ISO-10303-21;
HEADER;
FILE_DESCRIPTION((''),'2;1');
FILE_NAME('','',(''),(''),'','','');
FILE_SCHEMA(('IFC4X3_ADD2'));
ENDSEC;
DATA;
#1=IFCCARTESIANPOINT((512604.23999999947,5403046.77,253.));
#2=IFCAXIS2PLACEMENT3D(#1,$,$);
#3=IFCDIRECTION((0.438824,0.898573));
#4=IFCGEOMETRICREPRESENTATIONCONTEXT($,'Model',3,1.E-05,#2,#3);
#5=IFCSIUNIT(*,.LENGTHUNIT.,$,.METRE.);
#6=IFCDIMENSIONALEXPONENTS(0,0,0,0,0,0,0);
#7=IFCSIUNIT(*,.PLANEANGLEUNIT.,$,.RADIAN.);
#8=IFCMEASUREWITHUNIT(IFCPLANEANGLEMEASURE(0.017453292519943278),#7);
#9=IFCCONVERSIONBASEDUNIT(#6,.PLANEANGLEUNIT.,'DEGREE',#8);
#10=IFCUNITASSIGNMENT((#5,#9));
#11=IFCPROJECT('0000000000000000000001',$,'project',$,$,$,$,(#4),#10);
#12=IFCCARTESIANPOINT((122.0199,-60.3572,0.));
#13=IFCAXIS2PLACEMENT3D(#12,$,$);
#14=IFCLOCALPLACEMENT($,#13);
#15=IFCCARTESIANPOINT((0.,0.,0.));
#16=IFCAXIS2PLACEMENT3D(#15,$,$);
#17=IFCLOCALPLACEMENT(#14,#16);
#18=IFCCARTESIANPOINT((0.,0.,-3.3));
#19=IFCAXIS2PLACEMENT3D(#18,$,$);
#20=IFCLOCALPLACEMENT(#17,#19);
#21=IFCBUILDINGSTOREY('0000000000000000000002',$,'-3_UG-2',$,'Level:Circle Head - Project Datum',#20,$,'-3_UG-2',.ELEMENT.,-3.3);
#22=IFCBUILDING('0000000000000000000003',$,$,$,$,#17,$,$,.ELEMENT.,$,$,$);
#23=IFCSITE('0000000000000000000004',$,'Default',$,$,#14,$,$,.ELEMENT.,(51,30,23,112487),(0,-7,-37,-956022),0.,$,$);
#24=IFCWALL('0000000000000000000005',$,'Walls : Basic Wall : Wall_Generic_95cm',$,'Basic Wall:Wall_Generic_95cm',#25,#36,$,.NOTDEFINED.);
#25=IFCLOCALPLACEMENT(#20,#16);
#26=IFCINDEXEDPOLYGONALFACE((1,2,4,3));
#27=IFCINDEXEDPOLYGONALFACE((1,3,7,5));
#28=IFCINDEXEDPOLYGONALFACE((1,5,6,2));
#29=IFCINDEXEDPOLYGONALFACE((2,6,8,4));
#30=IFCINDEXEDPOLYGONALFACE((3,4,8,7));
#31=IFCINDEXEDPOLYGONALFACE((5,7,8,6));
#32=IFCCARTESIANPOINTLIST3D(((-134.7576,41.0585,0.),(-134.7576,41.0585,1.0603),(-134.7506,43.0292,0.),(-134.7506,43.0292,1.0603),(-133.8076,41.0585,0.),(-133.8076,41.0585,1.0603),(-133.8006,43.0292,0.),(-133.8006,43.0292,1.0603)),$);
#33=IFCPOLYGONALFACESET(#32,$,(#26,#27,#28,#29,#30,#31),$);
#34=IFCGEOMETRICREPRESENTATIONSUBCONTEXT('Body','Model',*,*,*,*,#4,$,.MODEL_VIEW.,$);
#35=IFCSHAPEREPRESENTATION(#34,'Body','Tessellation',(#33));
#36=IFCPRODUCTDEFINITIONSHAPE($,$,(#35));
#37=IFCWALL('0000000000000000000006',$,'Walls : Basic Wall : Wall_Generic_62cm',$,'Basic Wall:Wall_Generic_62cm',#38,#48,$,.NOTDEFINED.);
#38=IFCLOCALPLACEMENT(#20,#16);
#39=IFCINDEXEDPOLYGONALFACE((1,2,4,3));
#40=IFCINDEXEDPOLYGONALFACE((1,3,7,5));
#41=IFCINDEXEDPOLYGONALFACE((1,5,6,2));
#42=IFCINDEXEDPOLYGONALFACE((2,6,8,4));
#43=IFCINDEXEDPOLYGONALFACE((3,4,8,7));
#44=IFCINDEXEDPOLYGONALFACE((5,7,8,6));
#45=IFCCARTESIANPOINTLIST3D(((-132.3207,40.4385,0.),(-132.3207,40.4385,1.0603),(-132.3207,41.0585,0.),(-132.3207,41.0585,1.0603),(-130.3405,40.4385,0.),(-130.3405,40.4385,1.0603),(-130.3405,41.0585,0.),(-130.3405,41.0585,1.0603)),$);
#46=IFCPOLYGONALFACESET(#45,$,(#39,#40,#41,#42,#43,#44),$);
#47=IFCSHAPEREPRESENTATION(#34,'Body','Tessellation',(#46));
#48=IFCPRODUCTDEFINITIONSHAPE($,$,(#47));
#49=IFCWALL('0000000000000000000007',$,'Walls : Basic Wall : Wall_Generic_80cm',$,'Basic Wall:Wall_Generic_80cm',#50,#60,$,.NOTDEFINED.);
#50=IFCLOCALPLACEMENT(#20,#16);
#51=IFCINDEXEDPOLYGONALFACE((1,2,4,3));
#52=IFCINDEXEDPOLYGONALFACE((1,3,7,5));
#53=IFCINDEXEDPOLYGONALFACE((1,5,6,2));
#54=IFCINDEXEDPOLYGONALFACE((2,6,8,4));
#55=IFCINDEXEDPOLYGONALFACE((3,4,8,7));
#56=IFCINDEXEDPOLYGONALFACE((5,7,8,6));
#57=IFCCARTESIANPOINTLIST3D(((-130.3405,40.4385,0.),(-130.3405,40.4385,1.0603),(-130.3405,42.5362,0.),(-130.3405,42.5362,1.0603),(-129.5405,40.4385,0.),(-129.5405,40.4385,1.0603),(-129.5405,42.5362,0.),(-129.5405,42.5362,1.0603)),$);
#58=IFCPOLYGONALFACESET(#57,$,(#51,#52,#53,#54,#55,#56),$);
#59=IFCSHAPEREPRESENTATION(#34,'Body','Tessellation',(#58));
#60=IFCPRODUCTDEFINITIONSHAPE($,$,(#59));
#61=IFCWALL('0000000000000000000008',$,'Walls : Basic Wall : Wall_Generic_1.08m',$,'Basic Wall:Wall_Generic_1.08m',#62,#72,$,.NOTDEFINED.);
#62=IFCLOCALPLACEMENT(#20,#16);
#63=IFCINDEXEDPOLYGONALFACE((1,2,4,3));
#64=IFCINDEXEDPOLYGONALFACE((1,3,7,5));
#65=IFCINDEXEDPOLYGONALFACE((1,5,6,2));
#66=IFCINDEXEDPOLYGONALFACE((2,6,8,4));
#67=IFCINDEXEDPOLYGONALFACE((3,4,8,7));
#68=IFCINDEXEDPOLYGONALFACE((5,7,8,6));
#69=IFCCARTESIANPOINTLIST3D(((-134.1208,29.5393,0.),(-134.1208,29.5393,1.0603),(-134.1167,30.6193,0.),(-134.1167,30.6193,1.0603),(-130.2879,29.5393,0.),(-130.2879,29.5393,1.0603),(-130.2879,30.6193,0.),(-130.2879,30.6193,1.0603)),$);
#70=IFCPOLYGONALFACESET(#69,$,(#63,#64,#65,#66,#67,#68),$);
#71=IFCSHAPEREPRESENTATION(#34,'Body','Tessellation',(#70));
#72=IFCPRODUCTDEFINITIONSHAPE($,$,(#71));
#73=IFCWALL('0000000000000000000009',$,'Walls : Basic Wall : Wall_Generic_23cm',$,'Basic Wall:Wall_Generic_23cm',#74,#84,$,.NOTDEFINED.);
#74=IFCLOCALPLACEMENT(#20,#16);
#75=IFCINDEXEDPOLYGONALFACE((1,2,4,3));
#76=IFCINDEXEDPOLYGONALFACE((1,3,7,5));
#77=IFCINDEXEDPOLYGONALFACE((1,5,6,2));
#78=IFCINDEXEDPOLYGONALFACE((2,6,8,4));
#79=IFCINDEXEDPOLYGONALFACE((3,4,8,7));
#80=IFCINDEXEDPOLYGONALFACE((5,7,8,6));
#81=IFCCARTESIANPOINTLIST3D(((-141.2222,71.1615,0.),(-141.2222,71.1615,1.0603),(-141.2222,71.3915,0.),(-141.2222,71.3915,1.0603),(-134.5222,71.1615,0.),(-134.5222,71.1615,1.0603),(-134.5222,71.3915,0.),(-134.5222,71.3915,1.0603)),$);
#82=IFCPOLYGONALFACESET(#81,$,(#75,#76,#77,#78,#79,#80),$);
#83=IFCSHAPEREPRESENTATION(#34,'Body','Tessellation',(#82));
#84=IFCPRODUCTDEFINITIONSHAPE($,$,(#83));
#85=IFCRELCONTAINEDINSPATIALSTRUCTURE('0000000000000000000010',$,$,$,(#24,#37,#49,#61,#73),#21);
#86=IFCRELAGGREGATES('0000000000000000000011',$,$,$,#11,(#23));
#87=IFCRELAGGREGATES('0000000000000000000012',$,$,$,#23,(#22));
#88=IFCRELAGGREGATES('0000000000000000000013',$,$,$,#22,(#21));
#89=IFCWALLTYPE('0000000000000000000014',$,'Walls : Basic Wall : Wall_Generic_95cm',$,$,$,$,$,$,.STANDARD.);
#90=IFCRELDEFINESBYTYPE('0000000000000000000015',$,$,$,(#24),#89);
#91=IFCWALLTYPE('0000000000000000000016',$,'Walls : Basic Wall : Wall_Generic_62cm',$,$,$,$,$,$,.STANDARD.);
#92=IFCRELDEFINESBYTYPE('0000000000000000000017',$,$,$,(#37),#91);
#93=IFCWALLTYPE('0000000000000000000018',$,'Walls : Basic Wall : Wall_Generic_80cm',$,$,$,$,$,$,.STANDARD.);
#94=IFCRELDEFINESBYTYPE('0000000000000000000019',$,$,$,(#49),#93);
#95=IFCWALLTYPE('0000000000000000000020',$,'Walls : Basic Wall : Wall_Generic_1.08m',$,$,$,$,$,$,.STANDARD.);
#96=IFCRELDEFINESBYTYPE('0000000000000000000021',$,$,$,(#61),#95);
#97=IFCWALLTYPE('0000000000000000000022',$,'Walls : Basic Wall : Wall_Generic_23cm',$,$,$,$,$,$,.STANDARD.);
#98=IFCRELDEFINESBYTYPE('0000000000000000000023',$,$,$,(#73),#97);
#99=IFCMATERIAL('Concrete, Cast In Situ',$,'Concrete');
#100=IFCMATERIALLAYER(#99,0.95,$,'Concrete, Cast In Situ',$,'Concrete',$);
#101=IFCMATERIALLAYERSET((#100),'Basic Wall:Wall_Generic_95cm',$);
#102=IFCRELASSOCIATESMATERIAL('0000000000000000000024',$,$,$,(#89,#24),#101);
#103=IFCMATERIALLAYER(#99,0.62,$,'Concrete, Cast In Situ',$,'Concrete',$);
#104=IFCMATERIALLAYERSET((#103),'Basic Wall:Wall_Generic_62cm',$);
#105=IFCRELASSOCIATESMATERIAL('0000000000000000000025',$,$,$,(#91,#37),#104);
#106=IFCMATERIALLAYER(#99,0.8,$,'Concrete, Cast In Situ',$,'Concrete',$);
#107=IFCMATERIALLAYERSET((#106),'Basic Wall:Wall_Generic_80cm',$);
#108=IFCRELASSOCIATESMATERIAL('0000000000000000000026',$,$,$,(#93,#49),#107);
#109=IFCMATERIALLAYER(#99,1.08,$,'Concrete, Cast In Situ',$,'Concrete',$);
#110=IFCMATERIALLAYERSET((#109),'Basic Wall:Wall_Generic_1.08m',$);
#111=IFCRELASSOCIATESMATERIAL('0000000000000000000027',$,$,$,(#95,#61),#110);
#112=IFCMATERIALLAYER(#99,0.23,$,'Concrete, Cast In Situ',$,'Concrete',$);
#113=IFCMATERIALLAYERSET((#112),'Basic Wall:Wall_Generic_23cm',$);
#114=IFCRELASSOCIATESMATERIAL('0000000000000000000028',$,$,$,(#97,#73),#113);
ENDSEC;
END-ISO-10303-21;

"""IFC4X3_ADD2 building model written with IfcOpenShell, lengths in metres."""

from ifc_helpers import new_model, entity, si_unit, converted_unit, direction, frame, frame_2d, origin, place, context, subcontext, project, spatial, polyline, rectangle, outline, extrude, clip, halfspace, material, layer, layer_set, type_object, element, save


model = new_model("IFC4X3_ADD2")

# Units and contexts
model_context = context("Model", 3, precision=1e-05, world=frame((512604.23999999947, 5403046.77, 253.0)), true_north=direction((0.438824, 0.898573)))
body_context = subcontext(model_context, "Body", "Model", "MODEL_VIEW")
ifc_project = project(units=[si_unit("LENGTHUNIT", "METRE"), converted_unit("PLANEANGLEUNIT", "DEGREE", entity("IfcPlaneAngleMeasure", 0.017453292519943278), si_unit("PLANEANGLEUNIT", "RADIAN"), dimensions=[0, 0, 0, 0, 0, 0, 0])], contexts=[model_context])

# Site, building, storey
site_placement = place(None, frame((122.0199, -60.3572, 0.0)))
site = spatial("IfcSite", under=ifc_project, at=site_placement, Name="Default", CompositionType="ELEMENT", RefLatitude=(51, 30, 23, 112487), RefLongitude=(0, -7, -37, -956022), RefElevation=0.0)
building_placement = place(site_placement, origin())
building = spatial("IfcBuilding", under=site, at=building_placement, CompositionType="ELEMENT")
storey_placement = place(building_placement, frame((0.0, 0.0, -3.3)))
storey = spatial("IfcBuildingStorey", under=building, at=storey_placement, Name="-3_UG-2", ObjectType="Level:Circle Head - Project Datum", LongName="-3_UG-2", CompositionType="ELEMENT", Elevation=-3.3)

# Walls
ifc_material_1 = material(Name="Concrete, Cast In Situ", Category="Concrete")
ifc_layer_1 = layer(ifc_material_1, 0.95, Name="Concrete, Cast In Situ", Category="Concrete")
ifc_layer_set_1 = layer_set([ifc_layer_1], Name="Basic Wall:Wall_Generic_95cm")
wall_type_1 = type_object("IfcWallType", Name="Walls : Basic Wall : Wall_Generic_95cm", PredefinedType="STANDARD", material=ifc_layer_set_1)
wall_1_placement = place(storey_placement, frame((-134.2756, 43.0309, 0.0), z_axis=(0.0, 0.0, 1.0), x_axis=(-0.003592, -0.999994, 0.0)))
element("IfcWall", 1, at=wall_1_placement, inside=storey, type_object=wall_type_1, material=ifc_layer_set_1, Name="Walls : Basic Wall : Wall_Generic_95cm", ObjectType="Basic Wall:Wall_Generic_95cm", PredefinedType="NOTDEFINED", context=body_context, shape_type="Clipping", body=[
    clip(extrude(outline(polyline([(1.9741, -0.475), (1.9716, 0.2047), (1.9707, 0.475), (0.4, 0.475), (0.0, 0.475), (0.0034, -0.475), (1.9741, -0.475)])), origin(), (0.0, 0.0, 1.0), 1.0603), halfspace(origin(), True)),
])
ifc_layer_2 = layer(ifc_material_1, 0.62, Name="Concrete, Cast In Situ", Category="Concrete")
ifc_layer_set_2 = layer_set([ifc_layer_2], Name="Basic Wall:Wall_Generic_62cm")
wall_type_2 = type_object("IfcWallType", Name="Walls : Basic Wall : Wall_Generic_62cm", PredefinedType="STANDARD", material=ifc_layer_set_2)
wall_2_placement = place(storey_placement, frame((-132.3207, 40.7485, 0.0)))
element("IfcWall", 2, at=wall_2_placement, inside=storey, type_object=wall_type_2, material=ifc_layer_set_2, Name="Walls : Basic Wall : Wall_Generic_62cm", ObjectType="Basic Wall:Wall_Generic_62cm", PredefinedType="NOTDEFINED", context=body_context, shape_type="Clipping", body=[
    clip(extrude(rectangle(XDim=1.9802, YDim=0.62, at=frame_2d((0.9901, 0.0), x_axis=(-1.0, 0.0))), origin(), (0.0, 0.0, 1.0), 1.0603), halfspace(frame((0.0, 0.0, -1.56)), True)),
])
ifc_layer_3 = layer(ifc_material_1, 0.8, Name="Concrete, Cast In Situ", Category="Concrete")
ifc_layer_set_3 = layer_set([ifc_layer_3], Name="Basic Wall:Wall_Generic_80cm")
wall_type_3 = type_object("IfcWallType", Name="Walls : Basic Wall : Wall_Generic_80cm", PredefinedType="STANDARD", material=ifc_layer_set_3)
wall_3_placement = place(storey_placement, frame((-129.9405, 40.4385, 0.0), z_axis=(0.0, 0.0, 1.0), x_axis=(0.0, 1.0, 0.0)))
element("IfcWall", 3, at=wall_3_placement, inside=storey, type_object=wall_type_3, material=ifc_layer_set_3, Name="Walls : Basic Wall : Wall_Generic_80cm", ObjectType="Basic Wall:Wall_Generic_80cm", PredefinedType="NOTDEFINED", context=body_context, shape_type="SweptSolid", body=[
    extrude(rectangle(XDim=0.8, YDim=2.0977, at=frame_2d((0.0, 0.0), x_axis=(1.0, 0.0))), frame((1.0488, 0.0, 0.0), z_axis=(0.0, 0.0, 1.0), x_axis=(0.0, 1.0, 0.0)), (0.0, 0.0, 1.0), 1.0603),
])
ifc_layer_4 = layer(ifc_material_1, 1.08, Name="Concrete, Cast In Situ", Category="Concrete")
ifc_layer_set_4 = layer_set([ifc_layer_4], Name="Basic Wall:Wall_Generic_1.08m")
wall_type_4 = type_object("IfcWallType", Name="Walls : Basic Wall : Wall_Generic_1.08m", PredefinedType="STANDARD", material=ifc_layer_set_4)
wall_4_placement = place(storey_placement, frame((-134.1208, 30.0793, 0.0)))
element("IfcWall", 4, at=wall_4_placement, inside=storey, type_object=wall_type_4, material=ifc_layer_set_4, Name="Walls : Basic Wall : Wall_Generic_1.08m", ObjectType="Basic Wall:Wall_Generic_1.08m", PredefinedType="NOTDEFINED", context=body_context, shape_type="Clipping", body=[
    clip(extrude(outline(polyline([(3.8328, -0.54), (3.8328, 0.54), (0.004, 0.54), (0.0, -0.54), (3.8328, -0.54)])), origin(), (0.0, 0.0, 1.0), 1.0603), halfspace(origin(), True)),
])
ifc_layer_5 = layer(ifc_material_1, 0.23, Name="Concrete, Cast In Situ", Category="Concrete")
ifc_layer_set_5 = layer_set([ifc_layer_5], Name="Basic Wall:Wall_Generic_23cm")
wall_type_5 = type_object("IfcWallType", Name="Walls : Basic Wall : Wall_Generic_23cm", PredefinedType="STANDARD", material=ifc_layer_set_5)
wall_5_placement = place(storey_placement, frame((-134.5222, 71.2765, 0.0), z_axis=(0.0, 0.0, 1.0), x_axis=(-1.0, 0.0, 0.0)))
element("IfcWall", 5, at=wall_5_placement, inside=storey, type_object=wall_type_5, material=ifc_layer_set_5, Name="Walls : Basic Wall : Wall_Generic_23cm", ObjectType="Basic Wall:Wall_Generic_23cm", PredefinedType="NOTDEFINED", context=body_context, shape_type="Clipping", body=[
    clip(extrude(rectangle(XDim=6.7, YDim=0.23, at=frame_2d((3.35, 0.0), x_axis=(-1.0, 0.0))), origin(), (0.0, 0.0, 1.0), 1.0603), halfspace(origin(), True)),
])

save(model, "model.ifc")
